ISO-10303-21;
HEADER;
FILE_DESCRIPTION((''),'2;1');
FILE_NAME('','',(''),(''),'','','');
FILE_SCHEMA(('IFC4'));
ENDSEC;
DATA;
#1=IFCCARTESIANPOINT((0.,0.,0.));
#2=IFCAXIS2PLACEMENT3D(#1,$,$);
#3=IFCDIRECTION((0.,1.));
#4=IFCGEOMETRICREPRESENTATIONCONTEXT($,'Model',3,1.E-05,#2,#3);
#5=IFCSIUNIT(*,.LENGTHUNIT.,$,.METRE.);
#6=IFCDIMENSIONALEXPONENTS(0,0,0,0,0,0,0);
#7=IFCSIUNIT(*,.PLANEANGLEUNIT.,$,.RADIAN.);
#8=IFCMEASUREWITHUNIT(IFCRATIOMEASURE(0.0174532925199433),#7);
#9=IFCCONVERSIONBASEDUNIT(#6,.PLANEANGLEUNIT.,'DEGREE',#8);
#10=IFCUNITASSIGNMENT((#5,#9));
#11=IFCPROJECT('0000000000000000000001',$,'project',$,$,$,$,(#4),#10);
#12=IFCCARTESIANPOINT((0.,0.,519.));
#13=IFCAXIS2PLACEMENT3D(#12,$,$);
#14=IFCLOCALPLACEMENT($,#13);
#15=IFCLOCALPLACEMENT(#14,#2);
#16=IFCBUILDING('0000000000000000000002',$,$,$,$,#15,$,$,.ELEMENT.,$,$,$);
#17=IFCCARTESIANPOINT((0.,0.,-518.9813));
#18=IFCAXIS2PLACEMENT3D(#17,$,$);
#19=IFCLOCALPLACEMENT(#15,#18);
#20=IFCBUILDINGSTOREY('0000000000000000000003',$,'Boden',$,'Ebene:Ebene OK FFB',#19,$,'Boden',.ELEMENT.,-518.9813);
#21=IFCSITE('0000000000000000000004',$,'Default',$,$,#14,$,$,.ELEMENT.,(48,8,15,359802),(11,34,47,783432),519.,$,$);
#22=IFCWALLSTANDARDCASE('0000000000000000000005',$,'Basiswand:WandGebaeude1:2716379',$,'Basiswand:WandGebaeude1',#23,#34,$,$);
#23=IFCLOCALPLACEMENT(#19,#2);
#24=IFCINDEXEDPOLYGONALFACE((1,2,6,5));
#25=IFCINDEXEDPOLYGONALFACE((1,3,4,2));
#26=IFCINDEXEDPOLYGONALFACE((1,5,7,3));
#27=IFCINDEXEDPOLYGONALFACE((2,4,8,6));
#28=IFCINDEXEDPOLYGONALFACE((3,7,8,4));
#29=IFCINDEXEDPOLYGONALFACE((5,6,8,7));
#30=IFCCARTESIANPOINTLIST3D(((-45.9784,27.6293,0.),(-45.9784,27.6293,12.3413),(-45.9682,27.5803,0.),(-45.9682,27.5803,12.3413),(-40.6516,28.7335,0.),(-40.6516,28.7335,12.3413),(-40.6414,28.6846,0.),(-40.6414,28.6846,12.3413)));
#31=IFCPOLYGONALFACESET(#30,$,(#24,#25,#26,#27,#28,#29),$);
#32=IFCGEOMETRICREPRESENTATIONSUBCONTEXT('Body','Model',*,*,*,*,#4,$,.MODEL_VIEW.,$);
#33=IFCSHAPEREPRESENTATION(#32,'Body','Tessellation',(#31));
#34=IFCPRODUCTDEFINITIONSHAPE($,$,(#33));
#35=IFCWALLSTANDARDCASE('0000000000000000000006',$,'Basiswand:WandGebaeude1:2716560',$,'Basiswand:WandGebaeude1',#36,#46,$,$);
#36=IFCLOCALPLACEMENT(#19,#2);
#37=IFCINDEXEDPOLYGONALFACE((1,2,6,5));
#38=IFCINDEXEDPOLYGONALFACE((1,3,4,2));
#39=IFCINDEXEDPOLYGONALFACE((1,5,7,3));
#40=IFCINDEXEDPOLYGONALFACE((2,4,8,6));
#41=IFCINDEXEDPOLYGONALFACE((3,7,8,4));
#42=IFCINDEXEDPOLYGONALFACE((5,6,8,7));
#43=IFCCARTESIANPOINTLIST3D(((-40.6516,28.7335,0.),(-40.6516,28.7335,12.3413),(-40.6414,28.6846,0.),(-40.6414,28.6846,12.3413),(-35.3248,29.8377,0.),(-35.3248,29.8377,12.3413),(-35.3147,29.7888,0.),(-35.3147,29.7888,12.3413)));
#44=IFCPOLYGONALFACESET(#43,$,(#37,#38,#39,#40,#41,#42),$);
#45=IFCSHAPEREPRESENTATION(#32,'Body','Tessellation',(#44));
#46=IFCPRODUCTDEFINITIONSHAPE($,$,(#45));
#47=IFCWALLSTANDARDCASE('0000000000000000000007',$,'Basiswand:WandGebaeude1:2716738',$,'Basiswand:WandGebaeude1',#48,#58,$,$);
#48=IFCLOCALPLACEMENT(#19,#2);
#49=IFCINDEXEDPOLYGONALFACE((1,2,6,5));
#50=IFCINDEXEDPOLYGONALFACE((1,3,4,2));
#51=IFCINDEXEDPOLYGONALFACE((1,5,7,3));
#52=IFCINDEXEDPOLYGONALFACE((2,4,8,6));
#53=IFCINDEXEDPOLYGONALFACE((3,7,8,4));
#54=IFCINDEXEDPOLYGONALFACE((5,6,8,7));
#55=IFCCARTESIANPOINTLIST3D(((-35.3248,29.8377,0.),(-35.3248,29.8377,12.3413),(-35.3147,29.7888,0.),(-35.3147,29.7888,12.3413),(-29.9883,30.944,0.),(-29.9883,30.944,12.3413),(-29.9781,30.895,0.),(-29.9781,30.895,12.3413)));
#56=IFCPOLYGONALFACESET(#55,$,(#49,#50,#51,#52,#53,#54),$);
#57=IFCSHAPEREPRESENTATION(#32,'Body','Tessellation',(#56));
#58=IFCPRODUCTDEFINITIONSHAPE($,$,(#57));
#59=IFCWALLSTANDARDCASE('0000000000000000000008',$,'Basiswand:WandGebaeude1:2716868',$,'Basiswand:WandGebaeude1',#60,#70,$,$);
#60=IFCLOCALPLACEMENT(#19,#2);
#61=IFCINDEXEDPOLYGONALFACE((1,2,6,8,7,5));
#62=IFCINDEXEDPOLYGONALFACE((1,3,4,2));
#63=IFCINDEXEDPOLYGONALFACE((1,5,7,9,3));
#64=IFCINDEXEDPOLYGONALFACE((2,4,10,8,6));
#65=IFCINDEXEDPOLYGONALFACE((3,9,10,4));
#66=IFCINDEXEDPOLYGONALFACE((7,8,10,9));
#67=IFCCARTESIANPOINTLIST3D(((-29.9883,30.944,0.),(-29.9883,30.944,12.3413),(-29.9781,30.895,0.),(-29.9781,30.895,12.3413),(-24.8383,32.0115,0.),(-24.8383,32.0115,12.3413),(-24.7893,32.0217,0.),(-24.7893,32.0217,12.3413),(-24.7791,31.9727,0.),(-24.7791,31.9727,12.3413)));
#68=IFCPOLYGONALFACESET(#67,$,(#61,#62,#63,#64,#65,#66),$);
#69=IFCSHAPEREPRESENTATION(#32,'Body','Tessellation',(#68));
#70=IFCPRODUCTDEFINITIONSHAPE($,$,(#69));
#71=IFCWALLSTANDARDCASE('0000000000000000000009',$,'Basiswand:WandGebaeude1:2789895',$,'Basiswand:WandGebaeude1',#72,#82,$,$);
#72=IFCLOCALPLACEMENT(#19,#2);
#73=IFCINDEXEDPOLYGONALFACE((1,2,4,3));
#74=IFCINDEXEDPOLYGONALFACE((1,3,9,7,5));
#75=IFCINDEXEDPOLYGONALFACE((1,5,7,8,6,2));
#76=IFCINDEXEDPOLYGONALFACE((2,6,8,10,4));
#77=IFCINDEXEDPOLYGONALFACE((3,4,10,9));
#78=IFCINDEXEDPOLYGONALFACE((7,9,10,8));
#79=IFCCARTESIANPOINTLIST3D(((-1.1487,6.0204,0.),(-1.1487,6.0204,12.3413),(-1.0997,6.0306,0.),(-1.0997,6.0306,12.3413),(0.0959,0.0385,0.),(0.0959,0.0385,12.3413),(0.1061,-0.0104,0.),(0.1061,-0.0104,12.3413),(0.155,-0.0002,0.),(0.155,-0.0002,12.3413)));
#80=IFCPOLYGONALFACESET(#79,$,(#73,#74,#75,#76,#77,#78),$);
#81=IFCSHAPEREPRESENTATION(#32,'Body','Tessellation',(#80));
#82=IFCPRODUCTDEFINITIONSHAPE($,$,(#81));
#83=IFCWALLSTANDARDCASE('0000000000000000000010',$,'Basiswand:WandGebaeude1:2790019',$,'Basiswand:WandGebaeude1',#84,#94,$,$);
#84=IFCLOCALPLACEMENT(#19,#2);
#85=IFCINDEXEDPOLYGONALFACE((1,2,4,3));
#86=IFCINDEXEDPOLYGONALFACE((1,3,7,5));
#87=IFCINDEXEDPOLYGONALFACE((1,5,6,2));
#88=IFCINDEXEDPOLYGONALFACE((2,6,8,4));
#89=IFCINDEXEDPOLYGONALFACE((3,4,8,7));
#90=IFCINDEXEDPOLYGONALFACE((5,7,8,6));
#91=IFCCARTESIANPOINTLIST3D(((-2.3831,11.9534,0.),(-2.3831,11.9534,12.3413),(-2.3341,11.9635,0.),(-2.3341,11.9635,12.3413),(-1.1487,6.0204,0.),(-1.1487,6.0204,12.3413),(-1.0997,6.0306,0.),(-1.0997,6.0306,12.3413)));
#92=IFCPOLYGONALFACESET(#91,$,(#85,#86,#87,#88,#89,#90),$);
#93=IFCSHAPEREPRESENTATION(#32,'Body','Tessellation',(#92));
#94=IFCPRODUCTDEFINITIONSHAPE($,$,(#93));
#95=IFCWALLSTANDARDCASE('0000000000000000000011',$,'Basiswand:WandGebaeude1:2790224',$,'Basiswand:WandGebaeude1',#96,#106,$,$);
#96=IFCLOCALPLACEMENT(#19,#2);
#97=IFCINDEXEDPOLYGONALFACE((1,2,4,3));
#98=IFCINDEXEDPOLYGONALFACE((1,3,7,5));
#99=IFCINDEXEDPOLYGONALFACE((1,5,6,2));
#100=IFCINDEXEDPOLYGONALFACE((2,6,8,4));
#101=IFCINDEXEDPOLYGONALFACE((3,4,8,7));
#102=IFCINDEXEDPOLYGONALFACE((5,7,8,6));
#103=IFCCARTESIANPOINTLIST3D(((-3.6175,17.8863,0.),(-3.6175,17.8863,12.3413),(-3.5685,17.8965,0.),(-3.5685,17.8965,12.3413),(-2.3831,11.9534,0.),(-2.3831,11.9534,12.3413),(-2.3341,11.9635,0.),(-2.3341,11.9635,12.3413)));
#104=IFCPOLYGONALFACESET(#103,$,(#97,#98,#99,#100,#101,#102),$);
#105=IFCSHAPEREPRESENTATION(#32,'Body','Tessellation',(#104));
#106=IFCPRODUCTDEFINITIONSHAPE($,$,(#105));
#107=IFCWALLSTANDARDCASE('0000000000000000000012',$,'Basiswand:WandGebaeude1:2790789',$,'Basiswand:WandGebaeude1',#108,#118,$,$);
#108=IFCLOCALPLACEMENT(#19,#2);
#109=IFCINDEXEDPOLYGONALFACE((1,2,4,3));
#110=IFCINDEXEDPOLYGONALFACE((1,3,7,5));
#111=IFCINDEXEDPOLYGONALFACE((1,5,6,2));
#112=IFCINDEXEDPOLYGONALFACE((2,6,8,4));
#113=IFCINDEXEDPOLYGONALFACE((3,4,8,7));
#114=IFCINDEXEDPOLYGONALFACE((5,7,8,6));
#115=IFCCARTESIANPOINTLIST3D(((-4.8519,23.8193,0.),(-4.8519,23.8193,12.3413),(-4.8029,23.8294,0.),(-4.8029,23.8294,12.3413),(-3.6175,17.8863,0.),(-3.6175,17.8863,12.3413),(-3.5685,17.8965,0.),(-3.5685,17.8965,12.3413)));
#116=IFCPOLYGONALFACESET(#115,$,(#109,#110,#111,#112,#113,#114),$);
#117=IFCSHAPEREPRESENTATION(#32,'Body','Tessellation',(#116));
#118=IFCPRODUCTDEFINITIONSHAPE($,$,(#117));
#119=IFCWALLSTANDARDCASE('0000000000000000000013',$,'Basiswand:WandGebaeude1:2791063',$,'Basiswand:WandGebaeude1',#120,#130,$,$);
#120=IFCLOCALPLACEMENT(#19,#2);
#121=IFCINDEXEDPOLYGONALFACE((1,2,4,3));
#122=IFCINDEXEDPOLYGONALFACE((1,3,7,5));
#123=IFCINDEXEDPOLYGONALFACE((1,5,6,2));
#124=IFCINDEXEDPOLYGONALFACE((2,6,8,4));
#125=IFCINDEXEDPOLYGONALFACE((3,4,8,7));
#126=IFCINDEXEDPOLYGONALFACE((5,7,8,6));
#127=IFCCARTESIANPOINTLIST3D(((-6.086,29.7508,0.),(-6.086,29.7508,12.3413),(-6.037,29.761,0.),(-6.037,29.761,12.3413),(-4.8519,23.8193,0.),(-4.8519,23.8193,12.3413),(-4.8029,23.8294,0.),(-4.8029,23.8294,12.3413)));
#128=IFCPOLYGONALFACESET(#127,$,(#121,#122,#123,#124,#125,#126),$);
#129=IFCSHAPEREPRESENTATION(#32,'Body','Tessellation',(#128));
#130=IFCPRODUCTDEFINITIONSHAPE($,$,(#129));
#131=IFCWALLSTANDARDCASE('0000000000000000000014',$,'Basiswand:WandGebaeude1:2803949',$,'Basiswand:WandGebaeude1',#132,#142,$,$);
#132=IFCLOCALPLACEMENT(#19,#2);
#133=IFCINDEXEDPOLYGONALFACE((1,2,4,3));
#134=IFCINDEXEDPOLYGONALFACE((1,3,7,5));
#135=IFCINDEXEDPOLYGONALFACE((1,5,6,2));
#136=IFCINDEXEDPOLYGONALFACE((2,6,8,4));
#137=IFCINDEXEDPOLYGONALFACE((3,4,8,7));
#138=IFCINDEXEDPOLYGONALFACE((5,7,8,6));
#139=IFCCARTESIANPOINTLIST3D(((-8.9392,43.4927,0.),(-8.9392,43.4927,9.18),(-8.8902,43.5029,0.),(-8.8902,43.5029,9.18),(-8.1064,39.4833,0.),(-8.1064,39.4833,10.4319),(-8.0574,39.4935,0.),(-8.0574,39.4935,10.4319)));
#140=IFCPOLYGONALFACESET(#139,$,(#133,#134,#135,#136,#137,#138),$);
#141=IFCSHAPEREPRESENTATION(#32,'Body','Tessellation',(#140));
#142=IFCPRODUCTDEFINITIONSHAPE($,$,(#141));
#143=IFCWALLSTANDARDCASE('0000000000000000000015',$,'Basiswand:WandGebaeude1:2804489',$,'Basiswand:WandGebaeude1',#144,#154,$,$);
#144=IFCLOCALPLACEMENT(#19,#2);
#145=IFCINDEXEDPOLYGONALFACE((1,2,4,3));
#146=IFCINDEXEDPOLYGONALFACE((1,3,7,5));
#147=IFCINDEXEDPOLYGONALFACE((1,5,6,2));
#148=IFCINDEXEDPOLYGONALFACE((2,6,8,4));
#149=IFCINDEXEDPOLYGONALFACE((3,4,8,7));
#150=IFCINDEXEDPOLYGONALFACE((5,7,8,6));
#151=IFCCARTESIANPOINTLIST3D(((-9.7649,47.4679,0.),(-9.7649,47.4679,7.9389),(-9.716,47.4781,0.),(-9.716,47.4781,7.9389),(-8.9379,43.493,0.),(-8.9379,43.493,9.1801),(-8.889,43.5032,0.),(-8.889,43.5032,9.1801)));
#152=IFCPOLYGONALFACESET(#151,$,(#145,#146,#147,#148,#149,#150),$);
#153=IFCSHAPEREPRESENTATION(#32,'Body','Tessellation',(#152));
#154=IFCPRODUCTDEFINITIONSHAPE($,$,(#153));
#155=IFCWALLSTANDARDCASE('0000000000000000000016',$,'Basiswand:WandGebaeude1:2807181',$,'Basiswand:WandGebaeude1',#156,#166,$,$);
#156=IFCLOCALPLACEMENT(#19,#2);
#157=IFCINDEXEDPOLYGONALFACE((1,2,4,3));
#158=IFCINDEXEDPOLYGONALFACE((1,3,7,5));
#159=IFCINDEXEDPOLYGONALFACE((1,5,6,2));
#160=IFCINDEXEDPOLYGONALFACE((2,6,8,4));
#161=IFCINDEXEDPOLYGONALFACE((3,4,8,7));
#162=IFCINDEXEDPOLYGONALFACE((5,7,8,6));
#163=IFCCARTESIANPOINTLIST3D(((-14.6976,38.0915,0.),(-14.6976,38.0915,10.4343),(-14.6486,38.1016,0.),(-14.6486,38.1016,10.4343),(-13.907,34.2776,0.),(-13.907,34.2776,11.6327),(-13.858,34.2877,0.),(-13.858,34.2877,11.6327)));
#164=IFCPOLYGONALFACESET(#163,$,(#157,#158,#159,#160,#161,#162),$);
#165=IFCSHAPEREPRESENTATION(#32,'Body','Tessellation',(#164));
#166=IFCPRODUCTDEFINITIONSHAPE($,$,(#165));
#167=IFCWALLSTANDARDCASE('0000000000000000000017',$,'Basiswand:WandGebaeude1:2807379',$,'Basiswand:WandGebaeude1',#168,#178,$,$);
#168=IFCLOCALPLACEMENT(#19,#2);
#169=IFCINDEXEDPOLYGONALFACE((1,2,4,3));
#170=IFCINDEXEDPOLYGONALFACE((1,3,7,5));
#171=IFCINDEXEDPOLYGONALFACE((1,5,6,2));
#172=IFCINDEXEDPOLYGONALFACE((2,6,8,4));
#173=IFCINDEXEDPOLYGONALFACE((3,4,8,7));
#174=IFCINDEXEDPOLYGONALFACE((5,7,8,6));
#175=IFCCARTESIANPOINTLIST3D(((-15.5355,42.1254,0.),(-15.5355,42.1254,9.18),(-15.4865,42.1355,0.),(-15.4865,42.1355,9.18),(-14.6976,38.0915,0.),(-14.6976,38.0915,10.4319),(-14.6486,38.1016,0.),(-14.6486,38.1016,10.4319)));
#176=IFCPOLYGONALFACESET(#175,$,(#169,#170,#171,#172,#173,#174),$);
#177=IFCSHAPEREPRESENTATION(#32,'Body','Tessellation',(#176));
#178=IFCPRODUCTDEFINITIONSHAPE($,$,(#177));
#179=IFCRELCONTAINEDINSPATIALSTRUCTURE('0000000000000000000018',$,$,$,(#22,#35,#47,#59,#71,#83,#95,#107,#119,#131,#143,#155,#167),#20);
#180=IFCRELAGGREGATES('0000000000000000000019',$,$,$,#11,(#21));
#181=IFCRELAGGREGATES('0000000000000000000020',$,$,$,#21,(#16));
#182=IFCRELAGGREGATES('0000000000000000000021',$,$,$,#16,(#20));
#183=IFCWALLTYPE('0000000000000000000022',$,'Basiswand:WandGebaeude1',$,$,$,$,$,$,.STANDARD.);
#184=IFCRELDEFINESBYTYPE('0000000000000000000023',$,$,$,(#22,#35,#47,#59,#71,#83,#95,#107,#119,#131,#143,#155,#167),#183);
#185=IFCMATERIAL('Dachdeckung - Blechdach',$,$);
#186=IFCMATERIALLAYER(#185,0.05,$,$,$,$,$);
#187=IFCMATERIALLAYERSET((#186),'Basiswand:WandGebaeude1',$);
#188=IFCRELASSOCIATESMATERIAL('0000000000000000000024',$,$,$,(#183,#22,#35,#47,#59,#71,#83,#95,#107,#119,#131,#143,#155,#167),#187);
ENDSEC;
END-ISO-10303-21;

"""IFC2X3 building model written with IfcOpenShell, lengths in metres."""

from ifc_helpers import new_model, entity, si_unit, converted_unit, direction, frame, frame_2d, origin, place, context, subcontext, project, spatial, polyline, rectangle, outline, extrude, clip, halfspace, material, layer, layer_set, layer_usage, type_object, element, save


model = new_model("IFC2X3")

# Units and contexts
model_context = context("Model", 3, precision=1e-05, world=origin(), true_north=direction((0.0, 1.0)))
body_context = subcontext(model_context, "Body", "Model", "MODEL_VIEW")
ifc_project = project(units=[si_unit("LENGTHUNIT", "METRE"), converted_unit("PLANEANGLEUNIT", "DEGREE", entity("IfcRatioMeasure", 0.0174532925199433), si_unit("PLANEANGLEUNIT", "RADIAN"), dimensions=[0, 0, 0, 0, 0, 0, 0])], contexts=[model_context])

# Site, building, storey
site_placement = place(None, frame((0.0, 0.0, 519.0)))
site = spatial("IfcSite", under=ifc_project, at=site_placement, Name="Default", CompositionType="ELEMENT", RefLatitude=(48, 8, 15, 359802), RefLongitude=(11, 34, 47, 783432), RefElevation=519.0)
building_placement = place(site_placement, origin())
building = spatial("IfcBuilding", under=site, at=building_placement, CompositionType="ELEMENT")
storey_placement = place(building_placement, frame((0.0, 0.0, -518.9813)))
storey = spatial("IfcBuildingStorey", under=building, at=storey_placement, Name="Boden", ObjectType="Ebene:Ebene OK FFB", LongName="Boden", CompositionType="ELEMENT", Elevation=-518.9813)

# Walls
ifc_material_1 = material(Name="Dachdeckung - Blechdach")
ifc_layer_1 = layer(ifc_material_1, 0.05)
ifc_layer_set_1 = layer_set([ifc_layer_1], Name="Basiswand:WandGebaeude1")
wall_type_1 = type_object("IfcWallType", Name="Basiswand:WandGebaeude1", PredefinedType="STANDARD", material=ifc_layer_set_1)
ifc_layer_usage_1 = layer_usage(ifc_layer_set_1, "AXIS2", "NEGATIVE", 0.025)
wall_1_placement = place(storey_placement, frame((-45.9733, 27.6048, 0.0), z_axis=(0.0, 0.0, 1.0), x_axis=(0.979183, 0.20298, 0.0)))
element("IfcWallStandardCase", 1, at=wall_1_placement, inside=storey, type_object=wall_type_1, material=ifc_layer_usage_1, Name="Basiswand:WandGebaeude1:2716379", ObjectType="Basiswand:WandGebaeude1", context=body_context, shape_type="SweptSolid", body=[
    extrude(rectangle(XDim=5.44, YDim=0.05, at=frame_2d((2.72, 0.0), x_axis=(-1.0, 0.0))), origin(), (0.0, 0.0, 1.0), 12.3413),
])
ifc_layer_usage_2 = layer_usage(ifc_layer_set_1, "AXIS2", "NEGATIVE", 0.025)
wall_2_placement = place(storey_placement, frame((-40.6465, 28.709, 0.0), z_axis=(0.0, 0.0, 1.0), x_axis=(0.979183, 0.20298, 0.0)))
element("IfcWallStandardCase", 2, at=wall_2_placement, inside=storey, type_object=wall_type_1, material=ifc_layer_usage_2, Name="Basiswand:WandGebaeude1:2716560", ObjectType="Basiswand:WandGebaeude1", context=body_context, shape_type="SweptSolid", body=[
    extrude(rectangle(XDim=5.44, YDim=0.05, at=frame_2d((2.72, 0.0), x_axis=(-1.0, 0.0))), origin(), (0.0, 0.0, 1.0), 12.3413),
])
ifc_layer_usage_3 = layer_usage(ifc_layer_set_1, "AXIS2", "NEGATIVE", 0.025)
wall_3_placement = place(storey_placement, frame((-35.3198, 29.8132, 0.0), z_axis=(0.0, 0.0, 1.0), x_axis=(0.979183, 0.20298, 0.0)))
element("IfcWallStandardCase", 3, at=wall_3_placement, inside=storey, type_object=wall_type_1, material=ifc_layer_usage_3, Name="Basiswand:WandGebaeude1:2716738", ObjectType="Basiswand:WandGebaeude1", context=body_context, shape_type="SweptSolid", body=[
    extrude(rectangle(XDim=5.45, YDim=0.05, at=frame_2d((2.725, 0.0), x_axis=(-1.0, 0.0))), origin(), (0.0, 0.0, 1.0), 12.3413),
])
ifc_layer_usage_4 = layer_usage(ifc_layer_set_1, "AXIS2", "NEGATIVE", 0.025)
wall_4_placement = place(storey_placement, frame((-29.9832, 30.9195, 0.0), z_axis=(0.0, 0.0, 1.0), x_axis=(0.979183, 0.20298, 0.0)))
element("IfcWallStandardCase", 4, at=wall_4_placement, inside=storey, type_object=wall_type_1, material=ifc_layer_usage_4, Name="Basiswand:WandGebaeude1:2716868", ObjectType="Basiswand:WandGebaeude1", context=body_context, shape_type="SweptSolid", body=[
    extrude(outline(polyline([(5.3095, -0.025), (5.3095, 0.025), (5.2595, 0.025), (0.0, 0.025), (0.0, -0.025), (5.3095, -0.025)])), origin(), (0.0, 0.0, 1.0), 12.3413),
])
ifc_layer_usage_5 = layer_usage(ifc_layer_set_1, "AXIS2", "NEGATIVE", 0.025)
wall_5_placement = place(storey_placement, frame((-1.1242, 6.0255, 0.0), z_axis=(0.0, 0.0, 1.0), x_axis=(0.203696, -0.979034, 0.0)))
element("IfcWallStandardCase", 5, at=wall_5_placement, inside=storey, type_object=wall_type_1, material=ifc_layer_usage_5, Name="Basiswand:WandGebaeude1:2789895", ObjectType="Basiswand:WandGebaeude1", context=body_context, shape_type="SweptSolid", body=[
    extrude(outline(polyline([(6.16, -0.025), (6.16, 0.025), (0.0, 0.025), (0.0, -0.025), (6.11, -0.025), (6.16, -0.025)])), origin(), (0.0, 0.0, 1.0), 12.3413),
])
ifc_layer_usage_6 = layer_usage(ifc_layer_set_1, "AXIS2", "NEGATIVE", 0.025)
wall_6_placement = place(storey_placement, frame((-2.3586, 11.9585, 0.0), z_axis=(0.0, 0.0, 1.0), x_axis=(0.203696, -0.979034, 0.0)))
element("IfcWallStandardCase", 6, at=wall_6_placement, inside=storey, type_object=wall_type_1, material=ifc_layer_usage_6, Name="Basiswand:WandGebaeude1:2790019", ObjectType="Basiswand:WandGebaeude1", context=body_context, shape_type="SweptSolid", body=[
    extrude(rectangle(XDim=6.06, YDim=0.05, at=frame_2d((3.03, 0.0), x_axis=(-1.0, 0.0))), origin(), (0.0, 0.0, 1.0), 12.3413),
])
ifc_layer_usage_7 = layer_usage(ifc_layer_set_1, "AXIS2", "NEGATIVE", 0.025)
wall_7_placement = place(storey_placement, frame((-3.593, 17.8914, 0.0), z_axis=(0.0, 0.0, 1.0), x_axis=(0.203696, -0.979034, 0.0)))
element("IfcWallStandardCase", 7, at=wall_7_placement, inside=storey, type_object=wall_type_1, material=ifc_layer_usage_7, Name="Basiswand:WandGebaeude1:2790224", ObjectType="Basiswand:WandGebaeude1", context=body_context, shape_type="SweptSolid", body=[
    extrude(rectangle(XDim=6.06, YDim=0.05, at=frame_2d((3.03, 0.0), x_axis=(-1.0, 0.0))), origin(), (0.0, 0.0, 1.0), 12.3413),
])
ifc_layer_usage_8 = layer_usage(ifc_layer_set_1, "AXIS2", "NEGATIVE", 0.025)
wall_8_placement = place(storey_placement, frame((-4.8274, 23.8243, 0.0), z_axis=(0.0, 0.0, 1.0), x_axis=(0.203696, -0.979034, 0.0)))
element("IfcWallStandardCase", 8, at=wall_8_placement, inside=storey, type_object=wall_type_1, material=ifc_layer_usage_8, Name="Basiswand:WandGebaeude1:2790789", ObjectType="Basiswand:WandGebaeude1", context=body_context, shape_type="SweptSolid", body=[
    extrude(rectangle(XDim=6.06, YDim=0.05, at=frame_2d((3.03, 0.0), x_axis=(-1.0, 0.0))), origin(), (0.0, 0.0, 1.0), 12.3413),
])
ifc_layer_usage_9 = layer_usage(ifc_layer_set_1, "AXIS2", "NEGATIVE", 0.025)
wall_9_placement = place(storey_placement, frame((-6.0615, 29.7559, 0.0), z_axis=(0.0, 0.0, 1.0), x_axis=(0.203696, -0.979034, 0.0)))
element("IfcWallStandardCase", 9, at=wall_9_placement, inside=storey, type_object=wall_type_1, material=ifc_layer_usage_9, Name="Basiswand:WandGebaeude1:2791063", ObjectType="Basiswand:WandGebaeude1", context=body_context, shape_type="SweptSolid", body=[
    extrude(rectangle(XDim=6.0585, YDim=0.05, at=frame_2d((3.0293, 0.0), x_axis=(-1.0, 0.0))), origin(), (0.0, 0.0, 1.0), 12.3413),
])
ifc_layer_usage_10 = layer_usage(ifc_layer_set_1, "AXIS2", "NEGATIVE", 0.025)
wall_10_placement = place(storey_placement, frame((-8.0819, 39.4884, 0.0), z_axis=(0.0, 0.0, 1.0), x_axis=(-0.203381, 0.9791, 0.0)))
element("IfcWallStandardCase", 10, at=wall_10_placement, inside=storey, type_object=wall_type_1, material=ifc_layer_usage_10, Name="Basiswand:WandGebaeude1:2803949", ObjectType="Basiswand:WandGebaeude1", context=body_context, shape_type="Clipping", body=[
    clip(extrude(rectangle(XDim=4.095, YDim=0.05, at=frame_2d((2.0475, 0.0), x_axis=(-1.0, 0.0))), origin(), (0.0, 0.0, 1.0), 10.4319), halfspace(frame((0.0, -0.025, 10.4319), z_axis=(0.292372, 0.0, 0.956305), x_axis=(0.0, 1.0, 0.0)), False)),
])
ifc_layer_usage_11 = layer_usage(ifc_layer_set_1, "AXIS2", "NEGATIVE", 0.025)
wall_11_placement = place(storey_placement, frame((-8.9134, 43.4981, 0.0), z_axis=(0.0, 0.0, 1.0), x_axis=(-0.203696, 0.979034, 0.0)))
element("IfcWallStandardCase", 11, at=wall_11_placement, inside=storey, type_object=wall_type_1, material=ifc_layer_usage_11, Name="Basiswand:WandGebaeude1:2804489", ObjectType="Basiswand:WandGebaeude1", context=body_context, shape_type="Clipping", body=[
    clip(extrude(rectangle(XDim=4.06, YDim=0.05, at=frame_2d((2.03, 0.0), x_axis=(-1.0, 0.0))), origin(), (0.0, 0.0, 1.0), 9.1801), halfspace(frame((0.0, -0.025, 9.1801), z_axis=(0.292372, 0.0, 0.956305), x_axis=(0.0, 1.0, 0.0)), False)),
])
ifc_layer_usage_12 = layer_usage(ifc_layer_set_1, "AXIS2", "NEGATIVE", 0.025)
wall_12_placement = place(storey_placement, frame((-13.8825, 34.2826, 0.0), z_axis=(0.0, 0.0, 1.0), x_axis=(-0.20298, 0.979183, 0.0)))
element("IfcWallStandardCase", 12, at=wall_12_placement, inside=storey, type_object=wall_type_1, material=ifc_layer_usage_12, Name="Basiswand:WandGebaeude1:2807181", ObjectType="Basiswand:WandGebaeude1", context=body_context, shape_type="Clipping", body=[
    clip(extrude(rectangle(XDim=3.895, YDim=0.05, at=frame_2d((1.9475, 0.0), x_axis=(-1.0, 0.0))), origin(), (0.0, 0.0, 1.0), 11.6327), halfspace(frame((0.0, -0.025, 11.6327), z_axis=(0.294076, 0.0, 0.955782), x_axis=(0.0, 1.0, 0.0)), False)),
])
ifc_layer_usage_13 = layer_usage(ifc_layer_set_1, "AXIS2", "NEGATIVE", 0.025)
wall_13_placement = place(storey_placement, frame((-14.6731, 38.0965, 0.0), z_axis=(0.0, 0.0, 1.0), x_axis=(-0.203381, 0.9791, 0.0)))
element("IfcWallStandardCase", 13, at=wall_13_placement, inside=storey, type_object=wall_type_1, material=ifc_layer_usage_13, Name="Basiswand:WandGebaeude1:2807379", ObjectType="Basiswand:WandGebaeude1", context=body_context, shape_type="Clipping", body=[
    clip(extrude(rectangle(XDim=4.12, YDim=0.05, at=frame_2d((2.06, 0.0), x_axis=(-1.0, 0.0))), origin(), (0.0, 0.0, 1.0), 10.4319), halfspace(frame((0.0, -0.025, 10.4319), z_axis=(0.290748, 0.0, 0.9568), x_axis=(0.0, 1.0, 0.0)), False)),
])

save(model, "model.ifc")
